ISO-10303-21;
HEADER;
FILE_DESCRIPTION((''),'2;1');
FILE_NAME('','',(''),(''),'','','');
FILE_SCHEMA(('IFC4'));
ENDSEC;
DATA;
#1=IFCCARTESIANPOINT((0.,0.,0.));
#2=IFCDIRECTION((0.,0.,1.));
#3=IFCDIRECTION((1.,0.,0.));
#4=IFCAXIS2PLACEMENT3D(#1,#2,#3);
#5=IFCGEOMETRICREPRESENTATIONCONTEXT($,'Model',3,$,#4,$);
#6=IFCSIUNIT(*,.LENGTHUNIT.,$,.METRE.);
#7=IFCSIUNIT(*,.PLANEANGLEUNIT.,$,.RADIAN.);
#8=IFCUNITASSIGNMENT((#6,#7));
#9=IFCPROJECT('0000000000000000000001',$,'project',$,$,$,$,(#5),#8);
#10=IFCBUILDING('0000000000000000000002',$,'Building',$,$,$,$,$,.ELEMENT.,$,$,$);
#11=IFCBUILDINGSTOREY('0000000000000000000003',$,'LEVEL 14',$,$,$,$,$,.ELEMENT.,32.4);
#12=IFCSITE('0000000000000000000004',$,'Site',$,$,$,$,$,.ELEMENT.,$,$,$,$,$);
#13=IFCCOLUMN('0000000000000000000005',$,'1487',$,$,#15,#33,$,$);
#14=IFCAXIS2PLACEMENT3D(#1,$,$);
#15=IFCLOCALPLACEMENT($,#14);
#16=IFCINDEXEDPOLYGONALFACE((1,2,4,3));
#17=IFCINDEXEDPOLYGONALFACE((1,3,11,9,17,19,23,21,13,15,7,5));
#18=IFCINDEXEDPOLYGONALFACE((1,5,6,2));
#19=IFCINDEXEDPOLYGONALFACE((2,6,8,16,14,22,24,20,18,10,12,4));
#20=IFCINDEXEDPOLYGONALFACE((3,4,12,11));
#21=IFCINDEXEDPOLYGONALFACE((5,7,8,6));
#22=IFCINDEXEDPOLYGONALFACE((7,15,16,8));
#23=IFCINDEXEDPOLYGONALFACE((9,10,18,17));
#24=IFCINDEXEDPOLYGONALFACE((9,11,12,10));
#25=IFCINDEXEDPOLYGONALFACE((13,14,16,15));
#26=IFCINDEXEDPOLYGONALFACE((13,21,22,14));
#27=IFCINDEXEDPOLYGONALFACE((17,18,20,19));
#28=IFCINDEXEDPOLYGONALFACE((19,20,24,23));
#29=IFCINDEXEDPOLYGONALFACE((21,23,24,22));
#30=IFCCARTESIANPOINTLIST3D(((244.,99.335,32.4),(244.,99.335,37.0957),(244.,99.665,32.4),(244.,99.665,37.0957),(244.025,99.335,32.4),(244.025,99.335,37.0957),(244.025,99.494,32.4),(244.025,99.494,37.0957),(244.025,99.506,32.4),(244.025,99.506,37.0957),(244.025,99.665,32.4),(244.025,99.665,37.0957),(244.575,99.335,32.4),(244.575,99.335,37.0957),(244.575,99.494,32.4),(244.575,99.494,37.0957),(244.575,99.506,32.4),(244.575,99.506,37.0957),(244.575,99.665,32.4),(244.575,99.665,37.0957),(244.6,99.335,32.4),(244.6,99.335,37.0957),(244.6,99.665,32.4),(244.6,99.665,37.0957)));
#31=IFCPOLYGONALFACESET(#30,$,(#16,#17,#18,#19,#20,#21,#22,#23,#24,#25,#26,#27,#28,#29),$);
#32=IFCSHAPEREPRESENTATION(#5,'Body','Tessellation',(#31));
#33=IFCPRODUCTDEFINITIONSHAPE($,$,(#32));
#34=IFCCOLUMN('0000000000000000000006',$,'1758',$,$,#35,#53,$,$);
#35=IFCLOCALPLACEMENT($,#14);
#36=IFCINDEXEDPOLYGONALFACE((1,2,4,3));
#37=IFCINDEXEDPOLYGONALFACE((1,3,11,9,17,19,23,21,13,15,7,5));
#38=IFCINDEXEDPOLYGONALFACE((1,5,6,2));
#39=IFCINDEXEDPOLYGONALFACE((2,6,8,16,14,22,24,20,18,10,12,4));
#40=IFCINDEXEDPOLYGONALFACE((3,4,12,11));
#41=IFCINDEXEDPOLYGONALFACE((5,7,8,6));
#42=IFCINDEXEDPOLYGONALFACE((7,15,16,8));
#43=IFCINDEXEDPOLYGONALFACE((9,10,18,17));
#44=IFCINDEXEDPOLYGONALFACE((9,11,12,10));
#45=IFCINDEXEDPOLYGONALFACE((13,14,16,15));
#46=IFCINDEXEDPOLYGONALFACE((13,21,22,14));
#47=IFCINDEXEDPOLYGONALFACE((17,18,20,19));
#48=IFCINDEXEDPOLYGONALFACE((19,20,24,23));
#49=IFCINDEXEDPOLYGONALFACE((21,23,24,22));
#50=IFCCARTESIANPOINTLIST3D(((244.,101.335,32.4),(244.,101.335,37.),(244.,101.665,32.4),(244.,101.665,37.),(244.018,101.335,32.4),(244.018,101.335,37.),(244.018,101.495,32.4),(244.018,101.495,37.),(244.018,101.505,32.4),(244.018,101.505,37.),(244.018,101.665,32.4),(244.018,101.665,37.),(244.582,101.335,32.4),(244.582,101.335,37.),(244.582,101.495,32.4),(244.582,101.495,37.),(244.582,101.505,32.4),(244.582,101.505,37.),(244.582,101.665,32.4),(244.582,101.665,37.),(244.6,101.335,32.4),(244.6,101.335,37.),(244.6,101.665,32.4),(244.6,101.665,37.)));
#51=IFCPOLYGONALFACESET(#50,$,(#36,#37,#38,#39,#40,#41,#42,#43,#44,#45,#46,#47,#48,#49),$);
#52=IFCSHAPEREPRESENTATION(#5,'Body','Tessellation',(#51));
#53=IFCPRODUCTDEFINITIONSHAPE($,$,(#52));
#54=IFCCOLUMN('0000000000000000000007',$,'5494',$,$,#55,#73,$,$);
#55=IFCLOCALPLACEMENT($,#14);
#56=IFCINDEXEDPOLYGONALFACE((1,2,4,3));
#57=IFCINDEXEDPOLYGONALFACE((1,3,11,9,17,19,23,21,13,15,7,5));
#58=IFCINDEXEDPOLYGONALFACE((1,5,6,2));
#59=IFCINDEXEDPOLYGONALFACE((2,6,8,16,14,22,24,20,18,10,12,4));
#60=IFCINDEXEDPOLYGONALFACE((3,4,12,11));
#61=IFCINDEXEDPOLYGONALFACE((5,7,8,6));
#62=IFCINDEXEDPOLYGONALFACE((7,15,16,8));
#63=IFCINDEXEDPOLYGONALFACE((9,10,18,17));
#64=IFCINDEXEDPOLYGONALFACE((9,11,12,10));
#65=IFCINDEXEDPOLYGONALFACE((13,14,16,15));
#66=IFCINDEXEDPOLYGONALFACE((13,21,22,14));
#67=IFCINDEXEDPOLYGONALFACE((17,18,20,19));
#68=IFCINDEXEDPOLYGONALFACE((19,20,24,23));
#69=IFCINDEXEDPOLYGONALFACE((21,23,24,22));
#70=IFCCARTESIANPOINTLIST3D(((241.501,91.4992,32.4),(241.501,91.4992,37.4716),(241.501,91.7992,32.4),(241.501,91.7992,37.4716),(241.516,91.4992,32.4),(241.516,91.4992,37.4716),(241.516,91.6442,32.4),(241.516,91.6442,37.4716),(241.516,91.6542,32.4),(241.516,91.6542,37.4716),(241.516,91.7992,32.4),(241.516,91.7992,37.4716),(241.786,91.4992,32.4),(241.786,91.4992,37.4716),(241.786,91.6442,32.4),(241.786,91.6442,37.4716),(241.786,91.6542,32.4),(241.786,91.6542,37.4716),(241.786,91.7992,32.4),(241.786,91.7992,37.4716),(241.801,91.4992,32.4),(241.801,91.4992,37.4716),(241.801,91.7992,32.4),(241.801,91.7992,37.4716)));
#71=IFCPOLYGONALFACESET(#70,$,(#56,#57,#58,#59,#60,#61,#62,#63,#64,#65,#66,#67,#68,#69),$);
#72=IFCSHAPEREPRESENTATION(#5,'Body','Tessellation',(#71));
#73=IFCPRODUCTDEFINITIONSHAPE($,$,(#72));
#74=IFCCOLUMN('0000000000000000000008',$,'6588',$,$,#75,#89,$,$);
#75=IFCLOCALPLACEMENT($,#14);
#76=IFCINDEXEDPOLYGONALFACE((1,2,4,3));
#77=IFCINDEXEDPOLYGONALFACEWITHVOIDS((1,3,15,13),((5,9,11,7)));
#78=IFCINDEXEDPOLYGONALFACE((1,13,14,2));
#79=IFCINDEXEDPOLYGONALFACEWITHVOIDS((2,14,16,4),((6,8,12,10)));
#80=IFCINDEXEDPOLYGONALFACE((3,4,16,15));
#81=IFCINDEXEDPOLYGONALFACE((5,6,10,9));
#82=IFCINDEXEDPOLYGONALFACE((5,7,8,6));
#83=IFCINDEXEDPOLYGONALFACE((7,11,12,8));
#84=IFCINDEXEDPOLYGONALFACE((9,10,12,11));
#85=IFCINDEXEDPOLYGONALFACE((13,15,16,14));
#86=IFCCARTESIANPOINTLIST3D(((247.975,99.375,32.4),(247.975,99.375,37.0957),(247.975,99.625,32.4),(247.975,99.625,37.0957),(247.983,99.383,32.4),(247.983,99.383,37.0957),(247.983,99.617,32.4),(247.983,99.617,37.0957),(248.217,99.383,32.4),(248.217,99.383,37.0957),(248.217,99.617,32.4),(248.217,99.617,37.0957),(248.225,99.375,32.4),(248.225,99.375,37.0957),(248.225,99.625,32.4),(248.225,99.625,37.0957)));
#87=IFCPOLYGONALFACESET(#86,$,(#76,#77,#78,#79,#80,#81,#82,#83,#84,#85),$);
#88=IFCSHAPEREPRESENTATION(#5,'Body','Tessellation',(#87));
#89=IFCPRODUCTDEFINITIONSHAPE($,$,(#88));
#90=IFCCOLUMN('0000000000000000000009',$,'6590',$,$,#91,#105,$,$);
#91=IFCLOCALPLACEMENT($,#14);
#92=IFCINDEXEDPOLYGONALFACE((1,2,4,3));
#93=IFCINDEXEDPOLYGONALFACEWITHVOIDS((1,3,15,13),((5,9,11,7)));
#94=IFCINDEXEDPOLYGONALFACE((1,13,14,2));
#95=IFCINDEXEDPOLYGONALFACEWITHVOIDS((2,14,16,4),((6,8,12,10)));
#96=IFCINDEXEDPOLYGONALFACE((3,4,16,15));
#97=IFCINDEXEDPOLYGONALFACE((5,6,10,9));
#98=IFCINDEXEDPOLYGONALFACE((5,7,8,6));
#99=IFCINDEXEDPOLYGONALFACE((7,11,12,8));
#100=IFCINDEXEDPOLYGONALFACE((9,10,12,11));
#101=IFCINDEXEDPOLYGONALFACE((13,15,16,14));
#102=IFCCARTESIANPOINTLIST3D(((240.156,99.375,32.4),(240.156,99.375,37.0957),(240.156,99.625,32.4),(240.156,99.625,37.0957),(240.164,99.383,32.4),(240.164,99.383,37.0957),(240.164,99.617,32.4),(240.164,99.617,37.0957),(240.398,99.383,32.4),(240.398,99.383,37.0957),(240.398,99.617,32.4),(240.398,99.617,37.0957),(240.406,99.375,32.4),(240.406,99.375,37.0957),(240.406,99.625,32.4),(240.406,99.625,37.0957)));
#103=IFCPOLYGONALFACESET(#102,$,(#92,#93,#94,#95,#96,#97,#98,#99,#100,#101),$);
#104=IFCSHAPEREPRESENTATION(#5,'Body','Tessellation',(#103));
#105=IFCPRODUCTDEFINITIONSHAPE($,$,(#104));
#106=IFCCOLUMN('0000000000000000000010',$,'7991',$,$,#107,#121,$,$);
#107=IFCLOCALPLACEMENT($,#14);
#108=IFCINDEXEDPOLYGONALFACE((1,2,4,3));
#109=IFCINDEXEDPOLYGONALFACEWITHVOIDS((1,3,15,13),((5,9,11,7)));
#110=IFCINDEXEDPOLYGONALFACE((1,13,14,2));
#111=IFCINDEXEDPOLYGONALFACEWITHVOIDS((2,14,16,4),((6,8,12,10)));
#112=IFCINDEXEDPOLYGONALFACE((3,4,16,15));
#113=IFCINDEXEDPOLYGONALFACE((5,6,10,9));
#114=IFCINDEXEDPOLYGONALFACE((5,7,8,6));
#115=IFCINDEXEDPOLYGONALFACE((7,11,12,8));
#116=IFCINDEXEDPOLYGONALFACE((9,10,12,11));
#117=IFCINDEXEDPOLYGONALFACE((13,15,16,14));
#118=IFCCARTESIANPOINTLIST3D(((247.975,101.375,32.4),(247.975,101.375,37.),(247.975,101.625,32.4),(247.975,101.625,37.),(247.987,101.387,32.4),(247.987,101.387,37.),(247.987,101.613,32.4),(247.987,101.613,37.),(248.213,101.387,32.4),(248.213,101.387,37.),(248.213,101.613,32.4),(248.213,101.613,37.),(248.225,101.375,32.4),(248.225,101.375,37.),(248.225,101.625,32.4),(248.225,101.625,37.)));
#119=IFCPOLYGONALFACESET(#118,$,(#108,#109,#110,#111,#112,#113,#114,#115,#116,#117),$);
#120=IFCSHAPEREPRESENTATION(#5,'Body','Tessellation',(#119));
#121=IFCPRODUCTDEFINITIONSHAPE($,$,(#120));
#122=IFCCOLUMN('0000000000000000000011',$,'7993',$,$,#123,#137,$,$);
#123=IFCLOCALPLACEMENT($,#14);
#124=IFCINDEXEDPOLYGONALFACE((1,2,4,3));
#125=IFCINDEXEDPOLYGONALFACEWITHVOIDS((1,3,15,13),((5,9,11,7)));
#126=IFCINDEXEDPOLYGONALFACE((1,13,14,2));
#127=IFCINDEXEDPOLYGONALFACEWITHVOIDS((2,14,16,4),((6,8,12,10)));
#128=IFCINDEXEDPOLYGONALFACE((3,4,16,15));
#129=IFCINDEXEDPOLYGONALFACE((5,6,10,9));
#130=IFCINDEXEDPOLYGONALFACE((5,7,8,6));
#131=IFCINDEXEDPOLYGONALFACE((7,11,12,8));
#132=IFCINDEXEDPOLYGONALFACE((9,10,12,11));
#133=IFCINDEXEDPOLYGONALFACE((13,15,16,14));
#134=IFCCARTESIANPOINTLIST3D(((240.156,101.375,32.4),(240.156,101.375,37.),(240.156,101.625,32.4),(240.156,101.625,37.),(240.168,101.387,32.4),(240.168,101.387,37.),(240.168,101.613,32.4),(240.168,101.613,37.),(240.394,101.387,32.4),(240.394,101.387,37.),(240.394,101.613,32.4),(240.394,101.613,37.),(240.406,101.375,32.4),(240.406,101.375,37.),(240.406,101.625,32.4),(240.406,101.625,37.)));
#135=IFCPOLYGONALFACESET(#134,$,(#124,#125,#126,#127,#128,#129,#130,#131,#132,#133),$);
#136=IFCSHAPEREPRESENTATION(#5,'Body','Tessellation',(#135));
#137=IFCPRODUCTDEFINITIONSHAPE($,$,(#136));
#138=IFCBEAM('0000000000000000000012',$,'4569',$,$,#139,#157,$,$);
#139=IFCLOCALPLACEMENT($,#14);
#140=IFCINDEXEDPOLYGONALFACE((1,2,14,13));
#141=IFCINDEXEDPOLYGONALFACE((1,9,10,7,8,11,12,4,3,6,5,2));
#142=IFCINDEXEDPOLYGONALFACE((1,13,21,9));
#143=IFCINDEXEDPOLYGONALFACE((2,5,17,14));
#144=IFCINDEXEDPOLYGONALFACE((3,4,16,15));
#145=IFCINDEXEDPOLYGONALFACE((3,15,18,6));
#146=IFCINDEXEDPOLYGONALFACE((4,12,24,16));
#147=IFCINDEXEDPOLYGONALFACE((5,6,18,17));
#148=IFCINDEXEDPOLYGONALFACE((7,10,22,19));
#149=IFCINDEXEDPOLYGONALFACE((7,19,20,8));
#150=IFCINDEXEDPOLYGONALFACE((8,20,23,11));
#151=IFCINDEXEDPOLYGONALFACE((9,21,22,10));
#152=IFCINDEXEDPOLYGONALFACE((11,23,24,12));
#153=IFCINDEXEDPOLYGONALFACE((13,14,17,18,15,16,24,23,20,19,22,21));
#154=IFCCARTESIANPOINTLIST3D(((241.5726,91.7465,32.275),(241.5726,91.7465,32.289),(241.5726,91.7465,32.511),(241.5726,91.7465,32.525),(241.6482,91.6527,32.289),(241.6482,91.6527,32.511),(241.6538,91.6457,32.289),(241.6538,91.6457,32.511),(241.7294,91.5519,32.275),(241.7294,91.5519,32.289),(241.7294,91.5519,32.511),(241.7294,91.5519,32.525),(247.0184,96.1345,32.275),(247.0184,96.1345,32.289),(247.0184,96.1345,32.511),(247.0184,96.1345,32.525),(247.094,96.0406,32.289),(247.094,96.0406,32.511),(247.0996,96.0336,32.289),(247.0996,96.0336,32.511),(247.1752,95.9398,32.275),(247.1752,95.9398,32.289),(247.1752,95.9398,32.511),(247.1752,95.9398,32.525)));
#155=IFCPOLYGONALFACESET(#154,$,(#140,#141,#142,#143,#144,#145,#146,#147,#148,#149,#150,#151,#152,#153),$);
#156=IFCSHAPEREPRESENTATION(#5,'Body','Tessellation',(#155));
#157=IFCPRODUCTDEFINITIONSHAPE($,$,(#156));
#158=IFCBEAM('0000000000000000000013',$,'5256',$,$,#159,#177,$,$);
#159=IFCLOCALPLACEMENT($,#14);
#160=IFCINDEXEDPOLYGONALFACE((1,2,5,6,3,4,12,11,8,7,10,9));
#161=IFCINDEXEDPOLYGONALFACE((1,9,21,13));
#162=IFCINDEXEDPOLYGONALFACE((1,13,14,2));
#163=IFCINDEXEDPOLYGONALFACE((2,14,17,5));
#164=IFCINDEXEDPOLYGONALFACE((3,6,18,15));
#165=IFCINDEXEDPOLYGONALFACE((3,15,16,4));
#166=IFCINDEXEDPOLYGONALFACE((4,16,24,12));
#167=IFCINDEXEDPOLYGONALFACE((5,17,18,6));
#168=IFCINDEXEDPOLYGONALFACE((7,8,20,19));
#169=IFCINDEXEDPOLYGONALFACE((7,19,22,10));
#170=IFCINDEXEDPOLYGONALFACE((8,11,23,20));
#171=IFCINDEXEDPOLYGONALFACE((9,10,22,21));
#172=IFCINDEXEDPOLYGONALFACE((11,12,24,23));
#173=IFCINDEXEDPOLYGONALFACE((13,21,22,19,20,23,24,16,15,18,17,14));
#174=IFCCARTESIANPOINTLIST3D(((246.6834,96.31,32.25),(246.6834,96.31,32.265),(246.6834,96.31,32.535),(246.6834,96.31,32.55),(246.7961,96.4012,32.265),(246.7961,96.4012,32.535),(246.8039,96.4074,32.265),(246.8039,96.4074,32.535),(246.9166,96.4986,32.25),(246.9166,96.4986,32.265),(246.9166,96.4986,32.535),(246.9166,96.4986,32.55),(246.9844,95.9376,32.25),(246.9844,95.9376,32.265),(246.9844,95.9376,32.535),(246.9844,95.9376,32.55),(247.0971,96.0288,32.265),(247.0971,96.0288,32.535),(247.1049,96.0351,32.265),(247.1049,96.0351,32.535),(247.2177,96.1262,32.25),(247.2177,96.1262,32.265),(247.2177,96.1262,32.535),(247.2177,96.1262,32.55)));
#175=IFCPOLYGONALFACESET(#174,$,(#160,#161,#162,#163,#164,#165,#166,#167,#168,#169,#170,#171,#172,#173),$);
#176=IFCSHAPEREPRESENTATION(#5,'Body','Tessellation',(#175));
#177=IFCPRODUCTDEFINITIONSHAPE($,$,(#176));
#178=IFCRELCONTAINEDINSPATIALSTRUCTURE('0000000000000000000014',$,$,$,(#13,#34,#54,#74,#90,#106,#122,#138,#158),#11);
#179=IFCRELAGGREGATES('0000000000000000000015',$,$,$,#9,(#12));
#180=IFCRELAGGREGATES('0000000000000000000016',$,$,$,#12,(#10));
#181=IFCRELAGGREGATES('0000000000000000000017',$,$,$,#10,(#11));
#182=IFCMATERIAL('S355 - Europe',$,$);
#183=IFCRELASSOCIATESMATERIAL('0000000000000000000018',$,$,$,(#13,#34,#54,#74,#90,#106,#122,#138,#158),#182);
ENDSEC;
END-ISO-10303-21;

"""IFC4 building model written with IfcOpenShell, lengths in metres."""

from ifc_helpers import new_model, si_unit, frame, origin_with_axes, origin_2d_with_axis, place, context, project, spatial, hollow_rectangle, i_section, extrude, material, material_profile, profile_set, profile_usage, element, save


model = new_model("IFC4")

# Units and contexts
model_context = context("Model", 3, world=origin_with_axes())
ifc_project = project(units=[si_unit("LENGTHUNIT", "METRE"), si_unit("PLANEANGLEUNIT", "RADIAN")], contexts=[model_context])

# Site, building, storey
site = spatial("IfcSite", under=ifc_project, Name="Site", CompositionType="ELEMENT")
building = spatial("IfcBuilding", under=site, Name="Building", CompositionType="ELEMENT")
storey = spatial("IfcBuildingStorey", under=building, Name="LEVEL 14", CompositionType="ELEMENT", Elevation=32.4)

# Columns
ifc_material = material(Name="S355 - Europe")
ifc_material_profile_1 = material_profile(ifc_material, i_section(OverallWidth=0.33, OverallDepth=0.6, WebThickness=0.012, FlangeThickness=0.025, at=origin_2d_with_axis()))
ifc_profile_set_1 = profile_set([ifc_material_profile_1])
ifc_profile_usage_1 = profile_usage(ifc_profile_set_1, cardinal=10)
column_1_placement = place(None, frame((244.3, 99.5, 32.4), z_axis=(0.0, 0.0, 1.0), x_axis=(0.0, -1.0, 0.0)))
element("IfcColumn", 1, at=column_1_placement, inside=storey, material=ifc_profile_usage_1, Name="1487", context=model_context, shape_type="SweptSolid", body=[
    extrude(i_section(OverallWidth=0.33, OverallDepth=0.6, WebThickness=0.012, FlangeThickness=0.025, at=origin_2d_with_axis()), origin_with_axes(), (0.0, 0.0, 1.0), 4.6957),
])
ifc_material_profile_2 = material_profile(ifc_material, i_section(OverallWidth=0.33, OverallDepth=0.6, WebThickness=0.01, FlangeThickness=0.018, at=origin_2d_with_axis()))
ifc_profile_set_2 = profile_set([ifc_material_profile_2])
ifc_profile_usage_2 = profile_usage(ifc_profile_set_2, cardinal=10)
column_2_placement = place(None, frame((244.3, 101.5, 32.4), z_axis=(0.0, 0.0, 1.0), x_axis=(0.0, -1.0, 0.0)))
element("IfcColumn", 2, at=column_2_placement, inside=storey, material=ifc_profile_usage_2, Name="1758", context=model_context, shape_type="SweptSolid", body=[
    extrude(i_section(OverallWidth=0.33, OverallDepth=0.6, WebThickness=0.01, FlangeThickness=0.018, at=origin_2d_with_axis()), origin_with_axes(), (0.0, 0.0, 1.0), 4.6),
])
ifc_material_profile_3 = material_profile(ifc_material, i_section(OverallWidth=0.3, OverallDepth=0.3, WebThickness=0.01, FlangeThickness=0.015, at=origin_2d_with_axis()))
ifc_profile_set_3 = profile_set([ifc_material_profile_3])
ifc_profile_usage_3 = profile_usage(ifc_profile_set_3, cardinal=10)
column_3_placement = place(None, frame((241.651, 91.6492, 32.4), z_axis=(0.0, 0.0, 1.0), x_axis=(0.0, -1.0, 0.0)))
element("IfcColumn", 3, at=column_3_placement, inside=storey, material=ifc_profile_usage_3, Name="5494", context=model_context, shape_type="SweptSolid", body=[
    extrude(i_section(OverallWidth=0.3, OverallDepth=0.3, WebThickness=0.01, FlangeThickness=0.015, at=origin_2d_with_axis()), origin_with_axes(), (0.0, 0.0, 1.0), 5.0716),
])
ifc_material_profile_4 = material_profile(ifc_material, hollow_rectangle(XDim=0.25, YDim=0.25, WallThickness=0.008, at=origin_2d_with_axis()))
ifc_profile_set_4 = profile_set([ifc_material_profile_4])
ifc_profile_usage_4 = profile_usage(ifc_profile_set_4, cardinal=10)
column_4_placement = place(None, frame((248.1, 99.5, 32.4), z_axis=(0.0, 0.0, 1.0), x_axis=(0.0, -1.0, 0.0)))
element("IfcColumn", 4, at=column_4_placement, inside=storey, material=ifc_profile_usage_4, Name="6588", context=model_context, shape_type="SweptSolid", body=[
    extrude(hollow_rectangle(XDim=0.25, YDim=0.25, WallThickness=0.008, at=origin_2d_with_axis()), origin_with_axes(), (0.0, 0.0, 1.0), 4.6957),
])
ifc_material_profile_5 = material_profile(ifc_material, hollow_rectangle(XDim=0.25, YDim=0.25, WallThickness=0.008, at=origin_2d_with_axis()))
ifc_profile_set_5 = profile_set([ifc_material_profile_5])
ifc_profile_usage_5 = profile_usage(ifc_profile_set_5, cardinal=10)
column_5_placement = place(None, frame((240.281, 99.5, 32.4), z_axis=(0.0, 0.0, 1.0), x_axis=(0.0, -1.0, 0.0)))
element("IfcColumn", 5, at=column_5_placement, inside=storey, material=ifc_profile_usage_5, Name="6590", context=model_context, shape_type="SweptSolid", body=[
    extrude(hollow_rectangle(XDim=0.25, YDim=0.25, WallThickness=0.008, at=origin_2d_with_axis()), origin_with_axes(), (0.0, 0.0, 1.0), 4.6957),
])
ifc_material_profile_6 = material_profile(ifc_material, hollow_rectangle(XDim=0.25, YDim=0.25, WallThickness=0.012, at=origin_2d_with_axis()))
ifc_profile_set_6 = profile_set([ifc_material_profile_6])
ifc_profile_usage_6 = profile_usage(ifc_profile_set_6, cardinal=10)
column_6_placement = place(None, frame((248.1, 101.5, 32.4), z_axis=(0.0, 0.0, 1.0), x_axis=(0.0, -1.0, 0.0)))
element("IfcColumn", 6, at=column_6_placement, inside=storey, material=ifc_profile_usage_6, Name="7991", context=model_context, shape_type="SweptSolid", body=[
    extrude(hollow_rectangle(XDim=0.25, YDim=0.25, WallThickness=0.012, at=origin_2d_with_axis()), origin_with_axes(), (0.0, 0.0, 1.0), 4.6),
])
ifc_material_profile_7 = material_profile(ifc_material, hollow_rectangle(XDim=0.25, YDim=0.25, WallThickness=0.012, at=origin_2d_with_axis()))
ifc_profile_set_7 = profile_set([ifc_material_profile_7])
ifc_profile_usage_7 = profile_usage(ifc_profile_set_7, cardinal=10)
column_7_placement = place(None, frame((240.281, 101.5, 32.4), z_axis=(0.0, 0.0, 1.0), x_axis=(0.0, -1.0, 0.0)))
element("IfcColumn", 7, at=column_7_placement, inside=storey, material=ifc_profile_usage_7, Name="7993", context=model_context, shape_type="SweptSolid", body=[
    extrude(hollow_rectangle(XDim=0.25, YDim=0.25, WallThickness=0.012, at=origin_2d_with_axis()), origin_with_axes(), (0.0, 0.0, 1.0), 4.6),
])

# Beams
ifc_material_profile_8 = material_profile(ifc_material, i_section(OverallWidth=0.25, OverallDepth=0.25, WebThickness=0.009, FlangeThickness=0.014, at=origin_2d_with_axis()))
ifc_profile_set_8 = profile_set([ifc_material_profile_8])
ifc_profile_usage_8 = profile_usage(ifc_profile_set_8, cardinal=10)
beam_1_placement = place(None, frame((241.651, 91.6492, 32.4), z_axis=(0.77868, 0.627421, 0.0), x_axis=(-0.626214, 0.779651, 0.0)))
element("IfcBeam", 8, at=beam_1_placement, inside=storey, material=ifc_profile_usage_8, Name="4569", context=model_context, shape_type="SweptSolid", body=[
    extrude(i_section(OverallWidth=0.25, OverallDepth=0.25, WebThickness=0.009, FlangeThickness=0.014, at=origin_2d_with_axis()), origin_with_axes(), (0.0, 0.0, 1.0), 6.9936),
])
ifc_material_profile_9 = material_profile(ifc_material, i_section(OverallWidth=0.3, OverallDepth=0.3, WebThickness=0.01, FlangeThickness=0.015, at=origin_2d_with_axis()))
ifc_profile_set_9 = profile_set([ifc_material_profile_9])
ifc_profile_usage_9 = profile_usage(ifc_profile_set_9, cardinal=10)
beam_2_placement = place(None, frame((246.8, 96.4043, 32.4), z_axis=(0.628678, -0.777665, 0.0), x_axis=(0.777305, 0.629124, 0.0)))
element("IfcBeam", 9, at=beam_2_placement, inside=storey, material=ifc_profile_usage_9, Name="5256", context=model_context, shape_type="SweptSolid", body=[
    extrude(i_section(OverallWidth=0.3, OverallDepth=0.3, WebThickness=0.01, FlangeThickness=0.015, at=origin_2d_with_axis()), origin_with_axes(), (0.0, 0.0, 1.0), 0.4788),
])

save(model, "model.ifc")
